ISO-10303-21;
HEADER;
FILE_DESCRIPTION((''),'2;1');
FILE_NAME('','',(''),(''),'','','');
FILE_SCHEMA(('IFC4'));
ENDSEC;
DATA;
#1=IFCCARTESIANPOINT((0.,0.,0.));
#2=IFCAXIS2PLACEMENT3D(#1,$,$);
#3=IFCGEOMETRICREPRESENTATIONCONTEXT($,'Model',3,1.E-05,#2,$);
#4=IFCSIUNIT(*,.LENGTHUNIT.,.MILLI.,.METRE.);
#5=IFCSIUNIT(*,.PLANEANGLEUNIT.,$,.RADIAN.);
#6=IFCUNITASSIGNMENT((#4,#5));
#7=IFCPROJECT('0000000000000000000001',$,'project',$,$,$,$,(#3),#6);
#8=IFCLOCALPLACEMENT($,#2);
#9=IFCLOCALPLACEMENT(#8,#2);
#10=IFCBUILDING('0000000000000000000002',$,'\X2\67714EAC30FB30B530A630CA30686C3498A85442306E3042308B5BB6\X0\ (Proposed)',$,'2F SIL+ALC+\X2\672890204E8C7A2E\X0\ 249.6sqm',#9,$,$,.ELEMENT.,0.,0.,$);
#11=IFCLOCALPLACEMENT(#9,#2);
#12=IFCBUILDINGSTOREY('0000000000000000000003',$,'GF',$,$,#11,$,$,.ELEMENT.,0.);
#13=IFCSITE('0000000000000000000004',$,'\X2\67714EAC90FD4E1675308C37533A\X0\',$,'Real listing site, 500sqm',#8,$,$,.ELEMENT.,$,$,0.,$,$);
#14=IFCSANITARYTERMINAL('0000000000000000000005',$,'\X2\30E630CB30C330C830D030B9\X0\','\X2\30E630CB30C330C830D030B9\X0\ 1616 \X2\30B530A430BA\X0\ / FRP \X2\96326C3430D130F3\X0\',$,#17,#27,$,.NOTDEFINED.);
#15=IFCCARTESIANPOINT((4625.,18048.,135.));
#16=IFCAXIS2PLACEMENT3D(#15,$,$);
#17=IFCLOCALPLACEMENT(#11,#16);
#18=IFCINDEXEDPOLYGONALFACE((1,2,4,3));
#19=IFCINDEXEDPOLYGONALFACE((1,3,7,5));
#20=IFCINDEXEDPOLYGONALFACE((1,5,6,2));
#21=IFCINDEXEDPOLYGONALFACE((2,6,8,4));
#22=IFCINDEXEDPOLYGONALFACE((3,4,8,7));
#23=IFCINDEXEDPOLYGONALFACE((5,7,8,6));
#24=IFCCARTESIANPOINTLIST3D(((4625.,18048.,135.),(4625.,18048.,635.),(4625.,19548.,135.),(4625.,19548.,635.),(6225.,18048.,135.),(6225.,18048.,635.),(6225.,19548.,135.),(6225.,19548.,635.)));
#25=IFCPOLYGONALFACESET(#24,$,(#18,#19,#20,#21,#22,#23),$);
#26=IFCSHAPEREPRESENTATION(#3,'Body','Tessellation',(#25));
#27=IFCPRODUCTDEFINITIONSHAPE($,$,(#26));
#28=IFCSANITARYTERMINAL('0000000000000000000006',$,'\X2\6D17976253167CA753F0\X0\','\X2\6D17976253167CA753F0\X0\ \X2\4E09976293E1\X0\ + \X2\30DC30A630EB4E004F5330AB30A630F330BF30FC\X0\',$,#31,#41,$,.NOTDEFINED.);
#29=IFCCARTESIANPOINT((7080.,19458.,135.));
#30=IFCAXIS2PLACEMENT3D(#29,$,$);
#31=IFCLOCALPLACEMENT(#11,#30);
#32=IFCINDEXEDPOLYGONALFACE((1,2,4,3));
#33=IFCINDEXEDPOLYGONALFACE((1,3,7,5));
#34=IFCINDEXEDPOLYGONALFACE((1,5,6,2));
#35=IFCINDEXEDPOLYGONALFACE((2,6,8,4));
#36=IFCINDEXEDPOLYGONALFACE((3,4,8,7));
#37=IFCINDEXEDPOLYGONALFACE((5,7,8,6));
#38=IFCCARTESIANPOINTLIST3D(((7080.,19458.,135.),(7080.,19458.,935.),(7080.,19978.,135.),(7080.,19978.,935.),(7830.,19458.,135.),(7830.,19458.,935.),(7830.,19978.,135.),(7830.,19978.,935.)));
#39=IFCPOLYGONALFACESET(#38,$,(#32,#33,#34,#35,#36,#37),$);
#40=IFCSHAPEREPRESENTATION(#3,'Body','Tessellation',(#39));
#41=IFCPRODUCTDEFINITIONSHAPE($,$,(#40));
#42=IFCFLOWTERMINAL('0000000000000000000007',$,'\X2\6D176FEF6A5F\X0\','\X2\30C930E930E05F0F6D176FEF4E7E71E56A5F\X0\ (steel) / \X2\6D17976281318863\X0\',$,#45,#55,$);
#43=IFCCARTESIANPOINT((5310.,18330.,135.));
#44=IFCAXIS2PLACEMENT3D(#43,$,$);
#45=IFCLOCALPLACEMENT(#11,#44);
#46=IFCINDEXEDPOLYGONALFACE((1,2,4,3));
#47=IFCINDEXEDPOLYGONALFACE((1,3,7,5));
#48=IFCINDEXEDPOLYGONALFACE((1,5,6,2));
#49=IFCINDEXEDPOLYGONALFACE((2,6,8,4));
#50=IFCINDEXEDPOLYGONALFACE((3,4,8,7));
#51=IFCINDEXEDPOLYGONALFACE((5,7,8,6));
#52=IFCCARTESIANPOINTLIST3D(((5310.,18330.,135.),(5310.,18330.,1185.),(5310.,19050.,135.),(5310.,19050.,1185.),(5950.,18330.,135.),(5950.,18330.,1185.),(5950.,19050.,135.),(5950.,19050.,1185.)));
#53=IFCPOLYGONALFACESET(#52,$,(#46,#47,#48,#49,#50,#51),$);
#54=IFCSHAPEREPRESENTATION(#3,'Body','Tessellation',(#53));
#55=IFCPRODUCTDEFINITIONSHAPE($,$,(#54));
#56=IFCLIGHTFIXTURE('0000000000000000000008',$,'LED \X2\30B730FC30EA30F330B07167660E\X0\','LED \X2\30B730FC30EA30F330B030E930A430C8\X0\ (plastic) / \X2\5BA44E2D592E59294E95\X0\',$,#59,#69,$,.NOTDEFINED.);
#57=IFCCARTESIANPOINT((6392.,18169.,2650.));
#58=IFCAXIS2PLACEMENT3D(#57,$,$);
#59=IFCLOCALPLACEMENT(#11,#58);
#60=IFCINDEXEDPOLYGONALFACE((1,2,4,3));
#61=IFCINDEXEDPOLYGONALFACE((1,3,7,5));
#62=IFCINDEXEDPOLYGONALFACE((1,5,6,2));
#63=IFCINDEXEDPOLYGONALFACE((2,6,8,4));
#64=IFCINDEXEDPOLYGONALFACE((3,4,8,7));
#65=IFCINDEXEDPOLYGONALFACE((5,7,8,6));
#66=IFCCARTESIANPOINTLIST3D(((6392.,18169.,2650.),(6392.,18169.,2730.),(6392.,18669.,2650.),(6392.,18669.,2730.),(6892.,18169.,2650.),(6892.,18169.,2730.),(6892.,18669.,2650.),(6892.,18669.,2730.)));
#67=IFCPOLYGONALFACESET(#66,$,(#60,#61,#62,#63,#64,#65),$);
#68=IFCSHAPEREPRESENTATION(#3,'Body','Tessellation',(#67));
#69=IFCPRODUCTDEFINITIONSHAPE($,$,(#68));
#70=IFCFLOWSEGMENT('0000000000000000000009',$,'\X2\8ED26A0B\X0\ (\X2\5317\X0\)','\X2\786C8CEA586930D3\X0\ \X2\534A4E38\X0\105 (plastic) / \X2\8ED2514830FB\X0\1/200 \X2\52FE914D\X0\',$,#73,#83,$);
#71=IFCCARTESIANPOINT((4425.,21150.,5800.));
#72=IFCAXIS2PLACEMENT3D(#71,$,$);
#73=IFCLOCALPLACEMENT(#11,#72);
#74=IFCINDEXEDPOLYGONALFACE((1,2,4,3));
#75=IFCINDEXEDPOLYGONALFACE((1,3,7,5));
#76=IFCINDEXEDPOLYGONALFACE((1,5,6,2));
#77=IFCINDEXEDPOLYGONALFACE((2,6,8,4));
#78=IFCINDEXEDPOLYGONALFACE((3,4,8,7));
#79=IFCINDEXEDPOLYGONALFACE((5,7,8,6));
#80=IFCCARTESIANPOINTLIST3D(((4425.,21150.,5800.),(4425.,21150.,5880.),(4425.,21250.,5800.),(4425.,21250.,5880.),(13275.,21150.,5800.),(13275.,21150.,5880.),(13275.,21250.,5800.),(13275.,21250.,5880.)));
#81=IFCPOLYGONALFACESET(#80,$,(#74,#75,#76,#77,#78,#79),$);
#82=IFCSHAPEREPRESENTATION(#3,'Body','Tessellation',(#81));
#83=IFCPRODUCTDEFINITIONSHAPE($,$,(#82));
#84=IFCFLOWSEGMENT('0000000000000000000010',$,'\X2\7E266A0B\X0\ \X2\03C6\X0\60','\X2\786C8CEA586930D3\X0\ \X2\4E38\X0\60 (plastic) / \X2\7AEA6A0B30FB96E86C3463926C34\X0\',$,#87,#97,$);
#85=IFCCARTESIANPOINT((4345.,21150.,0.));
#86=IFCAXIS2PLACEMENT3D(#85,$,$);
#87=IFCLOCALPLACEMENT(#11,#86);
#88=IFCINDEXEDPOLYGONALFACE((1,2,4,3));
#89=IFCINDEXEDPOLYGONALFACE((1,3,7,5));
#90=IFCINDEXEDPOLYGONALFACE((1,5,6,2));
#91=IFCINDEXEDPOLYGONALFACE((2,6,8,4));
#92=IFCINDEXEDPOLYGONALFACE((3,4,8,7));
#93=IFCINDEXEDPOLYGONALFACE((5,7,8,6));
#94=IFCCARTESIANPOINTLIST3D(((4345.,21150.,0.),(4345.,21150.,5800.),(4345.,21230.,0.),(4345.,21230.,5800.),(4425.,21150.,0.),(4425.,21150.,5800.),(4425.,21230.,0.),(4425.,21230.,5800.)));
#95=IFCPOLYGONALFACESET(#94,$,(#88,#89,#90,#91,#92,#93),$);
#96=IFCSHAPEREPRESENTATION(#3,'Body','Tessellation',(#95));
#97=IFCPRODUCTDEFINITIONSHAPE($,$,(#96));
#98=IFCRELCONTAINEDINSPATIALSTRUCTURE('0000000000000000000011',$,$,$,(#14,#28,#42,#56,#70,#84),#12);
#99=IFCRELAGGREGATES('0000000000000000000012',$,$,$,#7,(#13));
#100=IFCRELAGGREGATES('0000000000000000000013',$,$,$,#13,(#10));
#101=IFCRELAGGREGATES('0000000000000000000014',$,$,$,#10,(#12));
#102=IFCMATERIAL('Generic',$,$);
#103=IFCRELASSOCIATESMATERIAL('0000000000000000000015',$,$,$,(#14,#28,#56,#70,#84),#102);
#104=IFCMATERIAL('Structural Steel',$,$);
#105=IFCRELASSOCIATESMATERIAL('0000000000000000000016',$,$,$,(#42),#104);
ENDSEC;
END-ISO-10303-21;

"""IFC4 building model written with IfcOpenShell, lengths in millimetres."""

from ifc_helpers import new_model, si_unit, frame, frame_2d, origin, place, context, project, spatial, rectangle, extrude, material, element, save


model = new_model("IFC4")

# Units and contexts
model_context = context("Model", 3, precision=1e-05, world=origin())
ifc_project = project(units=[si_unit("LENGTHUNIT", "METRE", prefix="MILLI"), si_unit("PLANEANGLEUNIT", "RADIAN")], contexts=[model_context])

# Site, building, storey
site_placement = place(None, origin())
site = spatial("IfcSite", under=ifc_project, at=site_placement, Name="東京都世田谷区", ObjectType="Real listing site, 500sqm", CompositionType="ELEMENT", RefElevation=0.0)
building_placement = place(site_placement, origin())
building = spatial("IfcBuilding", under=site, at=building_placement, Name="東京・サウナと水風呂のある家 (Proposed)", ObjectType="2F SIL+ALC+木造二種 249.6sqm", CompositionType="ELEMENT", ElevationOfRefHeight=0.0, ElevationOfTerrain=0.0)
storey_placement = place(building_placement, origin())
storey = spatial("IfcBuildingStorey", under=building, at=storey_placement, Name="GF", CompositionType="ELEMENT", Elevation=0.0)

# Sanitary terminals
ifc_material_1 = material(Name="Generic")
sanitary_terminal_1_placement = place(storey_placement, frame((4625.0, 18048.0, 135.0)))
element("IfcSanitaryTerminal", 1, at=sanitary_terminal_1_placement, inside=storey, material=ifc_material_1, Name="ユニットバス", Description="ユニットバス 1616 サイズ / FRP 防水パン", PredefinedType="NOTDEFINED", context=model_context, shape_type="SweptSolid", body=[
    extrude(rectangle(XDim=1600.0, YDim=1500.0, at=frame_2d((800.0, 750.0))), frame((4625.0, 18048.0, 135.0)), (0.0, 0.0, 1.0), 500.0),
])
sanitary_terminal_2_placement = place(storey_placement, frame((7080.0, 19458.0, 135.0)))
element("IfcSanitaryTerminal", 2, at=sanitary_terminal_2_placement, inside=storey, material=ifc_material_1, Name="洗面化粧台", Description="洗面化粧台 三面鏡 + ボウル一体カウンター", PredefinedType="NOTDEFINED", context=model_context, shape_type="SweptSolid", body=[
    extrude(rectangle(XDim=750.0, YDim=520.0, at=frame_2d((375.0, 260.0))), frame((7080.0, 19458.0, 135.0)), (0.0, 0.0, 1.0), 800.0),
])

# Flow terminal
ifc_material_2 = material(Name="Structural Steel")
flow_terminal_placement = place(storey_placement, frame((5310.0, 18330.0, 135.0)))
element("IfcFlowTerminal", 3, at=flow_terminal_placement, inside=storey, material=ifc_material_2, Name="洗濯機", Description="ドラム式洗濯乾燥機 (steel) / 洗面脱衣", context=model_context, shape_type="SweptSolid", body=[
    extrude(rectangle(XDim=640.0, YDim=720.0, at=frame_2d((320.0, 360.0))), frame((5310.0, 18330.0, 135.0)), (0.0, 0.0, 1.0), 1050.0),
])

# Light fixture
light_fixture_placement = place(storey_placement, frame((6392.0, 18169.0, 2650.0)))
element("IfcLightFixture", 4, at=light_fixture_placement, inside=storey, material=ifc_material_1, Name="LED シーリング照明", Description="LED シーリングライト (plastic) / 室中央天井", PredefinedType="NOTDEFINED", context=model_context, shape_type="SweptSolid", body=[
    extrude(rectangle(XDim=500.0, YDim=500.0, at=frame_2d((250.0, 250.0))), frame((6392.0, 18169.0, 2650.0)), (0.0, 0.0, 1.0), 80.0),
])

# Flow segments
flow_segment_1_placement = place(storey_placement, frame((4425.0, 21150.0, 5800.0)))
element("IfcFlowSegment", 5, at=flow_segment_1_placement, inside=storey, material=ifc_material_1, Name="軒樋 (北)", Description="硬質塩ビ 半丸105 (plastic) / 軒先・1/200 勾配", context=model_context, shape_type="SweptSolid", body=[
    extrude(rectangle(XDim=8850.0, YDim=100.0, at=frame_2d((4425.0, 50.0))), frame((4425.0, 21150.0, 5800.0)), (0.0, 0.0, 1.0), 80.0),
])
flow_segment_2_placement = place(storey_placement, frame((4345.0, 21150.0, 0.0)))
element("IfcFlowSegment", 6, at=flow_segment_2_placement, inside=storey, material=ifc_material_1, Name="縦樋 φ60", Description="硬質塩ビ 丸60 (plastic) / 竪樋・雨水排水", context=model_context, shape_type="SweptSolid", body=[
    extrude(rectangle(XDim=80.0, YDim=80.0, at=frame_2d((40.0, 40.0))), frame((4345.0, 21150.0, 0.0)), (0.0, 0.0, 1.0), 5800.0),
])

save(model, "model.ifc")
